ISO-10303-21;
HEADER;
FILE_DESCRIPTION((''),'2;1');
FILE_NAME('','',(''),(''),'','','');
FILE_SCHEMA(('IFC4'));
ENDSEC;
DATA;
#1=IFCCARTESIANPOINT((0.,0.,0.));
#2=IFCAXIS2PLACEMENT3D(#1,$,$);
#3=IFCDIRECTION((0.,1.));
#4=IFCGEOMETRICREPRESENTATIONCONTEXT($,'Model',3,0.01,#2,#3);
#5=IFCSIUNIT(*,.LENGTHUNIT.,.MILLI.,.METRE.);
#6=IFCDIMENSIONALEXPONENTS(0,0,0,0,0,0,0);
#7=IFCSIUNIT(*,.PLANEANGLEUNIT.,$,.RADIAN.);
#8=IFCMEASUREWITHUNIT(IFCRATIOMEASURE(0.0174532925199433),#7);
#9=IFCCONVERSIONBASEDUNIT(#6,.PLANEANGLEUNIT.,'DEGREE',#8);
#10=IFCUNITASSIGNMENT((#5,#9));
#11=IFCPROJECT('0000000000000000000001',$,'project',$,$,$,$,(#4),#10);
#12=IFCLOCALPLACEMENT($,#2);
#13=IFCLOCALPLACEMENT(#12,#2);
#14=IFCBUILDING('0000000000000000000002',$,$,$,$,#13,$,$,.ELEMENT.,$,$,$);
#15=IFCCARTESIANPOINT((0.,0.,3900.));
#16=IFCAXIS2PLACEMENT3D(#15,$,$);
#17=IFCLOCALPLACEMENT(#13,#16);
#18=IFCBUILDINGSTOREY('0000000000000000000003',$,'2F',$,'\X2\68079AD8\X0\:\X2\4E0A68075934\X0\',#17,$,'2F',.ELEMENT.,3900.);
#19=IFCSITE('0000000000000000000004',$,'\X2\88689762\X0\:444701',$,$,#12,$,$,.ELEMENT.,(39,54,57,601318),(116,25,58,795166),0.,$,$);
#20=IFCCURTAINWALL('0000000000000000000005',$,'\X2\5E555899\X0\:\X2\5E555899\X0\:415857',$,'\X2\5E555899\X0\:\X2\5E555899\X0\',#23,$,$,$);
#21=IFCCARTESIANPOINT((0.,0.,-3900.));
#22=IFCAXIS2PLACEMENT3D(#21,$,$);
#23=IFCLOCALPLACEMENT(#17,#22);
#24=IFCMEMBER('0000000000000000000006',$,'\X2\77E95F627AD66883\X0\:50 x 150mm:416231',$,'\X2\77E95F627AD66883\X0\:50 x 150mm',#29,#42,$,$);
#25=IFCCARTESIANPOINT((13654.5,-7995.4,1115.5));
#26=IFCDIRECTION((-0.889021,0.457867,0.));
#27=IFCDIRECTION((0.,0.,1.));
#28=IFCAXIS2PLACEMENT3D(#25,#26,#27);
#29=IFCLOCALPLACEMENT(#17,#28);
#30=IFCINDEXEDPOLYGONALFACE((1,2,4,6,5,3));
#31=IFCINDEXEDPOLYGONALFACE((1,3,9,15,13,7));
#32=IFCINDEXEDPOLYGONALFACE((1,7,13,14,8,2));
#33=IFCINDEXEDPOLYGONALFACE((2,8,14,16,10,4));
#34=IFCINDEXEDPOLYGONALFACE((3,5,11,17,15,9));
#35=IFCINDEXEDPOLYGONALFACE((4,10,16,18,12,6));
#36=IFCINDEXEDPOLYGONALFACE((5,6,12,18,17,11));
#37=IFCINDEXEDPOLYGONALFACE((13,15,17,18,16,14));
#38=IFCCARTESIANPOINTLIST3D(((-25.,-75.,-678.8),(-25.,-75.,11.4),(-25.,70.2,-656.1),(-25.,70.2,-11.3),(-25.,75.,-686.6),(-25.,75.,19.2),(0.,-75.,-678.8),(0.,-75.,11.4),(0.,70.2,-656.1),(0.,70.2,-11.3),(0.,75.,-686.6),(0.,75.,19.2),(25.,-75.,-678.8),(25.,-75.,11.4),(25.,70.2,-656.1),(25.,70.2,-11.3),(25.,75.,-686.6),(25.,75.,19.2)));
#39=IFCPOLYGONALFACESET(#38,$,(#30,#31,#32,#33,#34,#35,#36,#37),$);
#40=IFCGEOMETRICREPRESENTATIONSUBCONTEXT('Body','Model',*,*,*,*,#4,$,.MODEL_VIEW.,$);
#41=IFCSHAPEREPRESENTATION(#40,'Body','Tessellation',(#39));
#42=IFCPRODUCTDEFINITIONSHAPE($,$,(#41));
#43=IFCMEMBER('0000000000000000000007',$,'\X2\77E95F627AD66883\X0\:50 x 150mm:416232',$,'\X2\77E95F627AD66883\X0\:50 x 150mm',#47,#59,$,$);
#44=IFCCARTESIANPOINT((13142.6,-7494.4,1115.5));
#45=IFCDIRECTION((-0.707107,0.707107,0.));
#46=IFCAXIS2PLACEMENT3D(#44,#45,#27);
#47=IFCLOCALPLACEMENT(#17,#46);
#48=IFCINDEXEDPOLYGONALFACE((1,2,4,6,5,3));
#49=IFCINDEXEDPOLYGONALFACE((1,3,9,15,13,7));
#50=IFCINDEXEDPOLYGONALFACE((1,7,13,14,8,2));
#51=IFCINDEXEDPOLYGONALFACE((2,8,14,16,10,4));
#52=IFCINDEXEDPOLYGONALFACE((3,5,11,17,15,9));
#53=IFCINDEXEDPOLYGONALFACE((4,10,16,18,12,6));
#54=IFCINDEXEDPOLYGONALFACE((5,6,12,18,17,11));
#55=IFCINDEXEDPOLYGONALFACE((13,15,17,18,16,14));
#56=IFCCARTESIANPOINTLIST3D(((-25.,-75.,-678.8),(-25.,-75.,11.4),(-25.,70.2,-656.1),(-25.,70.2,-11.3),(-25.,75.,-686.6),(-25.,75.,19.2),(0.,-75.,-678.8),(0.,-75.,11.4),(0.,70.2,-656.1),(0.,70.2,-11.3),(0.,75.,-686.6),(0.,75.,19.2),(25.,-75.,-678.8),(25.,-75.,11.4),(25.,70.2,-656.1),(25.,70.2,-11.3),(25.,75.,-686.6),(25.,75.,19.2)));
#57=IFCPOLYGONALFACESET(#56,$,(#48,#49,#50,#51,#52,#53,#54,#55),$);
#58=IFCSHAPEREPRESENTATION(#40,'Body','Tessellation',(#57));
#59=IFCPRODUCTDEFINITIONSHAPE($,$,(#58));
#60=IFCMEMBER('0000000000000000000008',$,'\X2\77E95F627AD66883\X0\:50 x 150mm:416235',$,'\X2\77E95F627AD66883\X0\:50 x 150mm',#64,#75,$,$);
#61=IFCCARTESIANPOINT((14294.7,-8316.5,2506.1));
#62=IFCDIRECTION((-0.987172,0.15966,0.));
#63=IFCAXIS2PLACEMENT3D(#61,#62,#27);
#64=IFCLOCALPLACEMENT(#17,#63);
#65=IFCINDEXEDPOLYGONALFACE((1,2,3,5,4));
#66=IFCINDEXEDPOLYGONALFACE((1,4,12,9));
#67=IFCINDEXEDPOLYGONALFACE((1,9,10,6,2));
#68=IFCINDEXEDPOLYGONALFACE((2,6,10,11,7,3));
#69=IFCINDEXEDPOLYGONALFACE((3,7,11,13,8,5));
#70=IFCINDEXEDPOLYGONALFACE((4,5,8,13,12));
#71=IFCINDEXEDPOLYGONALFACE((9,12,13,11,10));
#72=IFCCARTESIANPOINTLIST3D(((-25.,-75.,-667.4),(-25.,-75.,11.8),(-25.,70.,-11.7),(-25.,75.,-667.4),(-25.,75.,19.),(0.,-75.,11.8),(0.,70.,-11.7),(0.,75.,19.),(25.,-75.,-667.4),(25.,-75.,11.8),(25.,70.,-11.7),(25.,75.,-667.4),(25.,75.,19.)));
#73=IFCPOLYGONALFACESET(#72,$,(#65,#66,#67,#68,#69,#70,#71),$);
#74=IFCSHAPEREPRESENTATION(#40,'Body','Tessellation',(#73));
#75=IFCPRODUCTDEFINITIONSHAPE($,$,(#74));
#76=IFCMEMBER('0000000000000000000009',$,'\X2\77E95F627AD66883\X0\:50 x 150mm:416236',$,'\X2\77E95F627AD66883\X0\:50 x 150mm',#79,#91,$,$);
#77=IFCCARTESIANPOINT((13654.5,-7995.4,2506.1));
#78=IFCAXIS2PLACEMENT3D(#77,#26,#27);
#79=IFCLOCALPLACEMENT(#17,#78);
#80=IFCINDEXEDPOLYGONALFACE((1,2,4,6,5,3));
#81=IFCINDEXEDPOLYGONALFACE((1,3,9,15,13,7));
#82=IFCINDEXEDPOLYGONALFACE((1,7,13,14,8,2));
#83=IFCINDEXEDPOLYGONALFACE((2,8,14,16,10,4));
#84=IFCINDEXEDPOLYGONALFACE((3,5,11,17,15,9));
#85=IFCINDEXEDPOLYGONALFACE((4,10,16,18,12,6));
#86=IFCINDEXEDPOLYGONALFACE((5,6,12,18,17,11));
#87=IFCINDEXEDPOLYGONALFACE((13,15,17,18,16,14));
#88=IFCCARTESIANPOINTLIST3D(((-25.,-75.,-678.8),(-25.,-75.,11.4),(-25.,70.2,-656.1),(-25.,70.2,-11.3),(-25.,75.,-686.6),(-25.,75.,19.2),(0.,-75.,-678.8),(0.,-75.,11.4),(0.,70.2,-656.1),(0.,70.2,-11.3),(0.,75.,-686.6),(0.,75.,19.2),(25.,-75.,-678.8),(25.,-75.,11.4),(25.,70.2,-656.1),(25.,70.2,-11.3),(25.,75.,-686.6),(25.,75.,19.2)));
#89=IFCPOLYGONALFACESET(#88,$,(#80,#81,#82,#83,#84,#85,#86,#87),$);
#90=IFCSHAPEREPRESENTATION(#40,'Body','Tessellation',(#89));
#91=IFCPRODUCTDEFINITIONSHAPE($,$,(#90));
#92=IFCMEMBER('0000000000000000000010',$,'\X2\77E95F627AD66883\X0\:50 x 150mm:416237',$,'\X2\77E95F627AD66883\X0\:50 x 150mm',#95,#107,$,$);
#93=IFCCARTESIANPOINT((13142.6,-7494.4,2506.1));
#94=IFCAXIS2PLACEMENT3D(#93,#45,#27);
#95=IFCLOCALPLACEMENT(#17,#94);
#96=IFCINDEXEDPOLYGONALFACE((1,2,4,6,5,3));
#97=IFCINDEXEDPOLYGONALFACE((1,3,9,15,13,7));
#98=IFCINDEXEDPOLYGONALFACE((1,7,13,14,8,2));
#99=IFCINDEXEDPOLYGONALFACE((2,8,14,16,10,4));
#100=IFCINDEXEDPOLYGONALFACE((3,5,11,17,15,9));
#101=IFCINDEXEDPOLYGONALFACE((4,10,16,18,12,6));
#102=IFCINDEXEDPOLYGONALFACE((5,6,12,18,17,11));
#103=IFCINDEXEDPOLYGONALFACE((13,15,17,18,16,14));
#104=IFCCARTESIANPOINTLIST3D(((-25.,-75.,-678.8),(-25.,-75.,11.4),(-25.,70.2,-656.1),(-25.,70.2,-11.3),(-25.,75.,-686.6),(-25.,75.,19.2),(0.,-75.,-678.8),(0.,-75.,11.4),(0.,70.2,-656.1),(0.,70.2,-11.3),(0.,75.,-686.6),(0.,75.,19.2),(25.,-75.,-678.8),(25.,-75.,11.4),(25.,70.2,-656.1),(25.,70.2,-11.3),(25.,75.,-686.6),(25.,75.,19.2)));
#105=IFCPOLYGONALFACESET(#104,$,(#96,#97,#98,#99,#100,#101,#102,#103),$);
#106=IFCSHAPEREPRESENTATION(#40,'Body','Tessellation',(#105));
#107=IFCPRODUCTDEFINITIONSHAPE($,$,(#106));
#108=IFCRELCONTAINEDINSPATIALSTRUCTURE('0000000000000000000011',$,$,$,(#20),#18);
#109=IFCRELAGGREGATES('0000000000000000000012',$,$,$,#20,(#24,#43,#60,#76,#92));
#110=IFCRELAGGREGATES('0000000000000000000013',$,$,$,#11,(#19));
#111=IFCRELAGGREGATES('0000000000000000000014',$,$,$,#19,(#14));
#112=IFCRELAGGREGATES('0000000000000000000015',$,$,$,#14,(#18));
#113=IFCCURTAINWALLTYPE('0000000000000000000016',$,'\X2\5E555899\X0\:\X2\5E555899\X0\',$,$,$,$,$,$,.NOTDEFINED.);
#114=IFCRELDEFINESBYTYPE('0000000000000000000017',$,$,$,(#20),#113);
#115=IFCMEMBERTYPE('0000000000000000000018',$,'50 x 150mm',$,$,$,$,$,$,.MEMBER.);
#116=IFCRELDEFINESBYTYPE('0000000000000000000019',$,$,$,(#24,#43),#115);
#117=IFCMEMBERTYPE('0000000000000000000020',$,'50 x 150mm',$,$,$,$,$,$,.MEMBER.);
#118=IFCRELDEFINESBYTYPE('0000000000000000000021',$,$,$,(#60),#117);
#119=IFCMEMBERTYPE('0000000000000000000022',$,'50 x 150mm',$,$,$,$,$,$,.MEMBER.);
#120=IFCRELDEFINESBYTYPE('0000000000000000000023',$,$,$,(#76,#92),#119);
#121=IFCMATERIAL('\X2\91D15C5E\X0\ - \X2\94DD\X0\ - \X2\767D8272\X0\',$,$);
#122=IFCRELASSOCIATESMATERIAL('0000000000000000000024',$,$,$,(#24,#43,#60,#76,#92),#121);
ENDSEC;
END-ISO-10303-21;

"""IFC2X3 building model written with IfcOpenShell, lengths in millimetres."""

from ifc_helpers import new_model, entity, si_unit, converted_unit, direction, frame, origin, origin_2d_with_axis, place, context, subcontext, project, spatial, polyline, rectangle, extrude, clip, bounded_halfspace, source, transform, mapped, material, type_object, type_shapes, element, aggregate, save


model = new_model("IFC2X3")

# Units and contexts
model_context = context("Model", 3, precision=0.01, world=origin(), true_north=direction((0.0, 1.0)))
body_context = subcontext(model_context, "Body", "Model", "MODEL_VIEW")
ifc_project = project(units=[si_unit("LENGTHUNIT", "METRE", prefix="MILLI"), converted_unit("PLANEANGLEUNIT", "DEGREE", entity("IfcRatioMeasure", 0.0174532925199433), si_unit("PLANEANGLEUNIT", "RADIAN"), dimensions=[0, 0, 0, 0, 0, 0, 0])], contexts=[model_context])

# Site, building, storey
site_placement = place(None, origin())
site = spatial("IfcSite", under=ifc_project, at=site_placement, Name="表面:444701", CompositionType="ELEMENT", RefLatitude=(39, 54, 57, 601318), RefLongitude=(116, 25, 58, 795166), RefElevation=0.0)
building_placement = place(site_placement, origin())
building = spatial("IfcBuilding", under=site, at=building_placement, CompositionType="ELEMENT")
storey_placement = place(building_placement, frame((0.0, 0.0, 3900.0)))
storey = spatial("IfcBuildingStorey", under=building, at=storey_placement, Name="2F", ObjectType="标高:上标头", LongName="2F", CompositionType="ELEMENT", Elevation=3900.0)

# Curtain wall, members
curtain_wall_type = type_object("IfcCurtainWallType", Name="幕墙:幕墙", PredefinedType="NOTDEFINED")
curtain_wall_1_placement = place(storey_placement, frame((0.0, 0.0, -3900.0)))
curtain_wall_1 = element("IfcCurtainWall", 1, at=curtain_wall_1_placement, inside=storey, type_object=curtain_wall_type, Name="幕墙:幕墙:415857", ObjectType="幕墙:幕墙")
ifc_material_1 = material(Name="金属 - 铝 - 白色")
member_type_1 = type_object("IfcMemberType", Name="50 x 150mm", PredefinedType="MEMBER")
shared_shape_1 = source(origin(), body_context, "Body", "Clipping", [
    clip(clip(clip(clip(clip(clip(clip(clip(extrude(rectangle(XDim=150.0, YDim=50.0, at=origin_2d_with_axis()), frame((0.0, 0.0, -686.6), z_axis=(0.0, 0.0, 1.0), x_axis=(0.0, -1.0, 0.0)), (0.0, 0.0, 1.0), 705.8), bounded_halfspace(frame((-1415.5, -78.0, -679.3), z_axis=(0.0, 0.154283, -0.988027), x_axis=(1.0, 0.0, 0.0)), False, frame((0.0, 0.0, -686.6), z_axis=(0.0, 0.0, 1.0), x_axis=(0.0, -1.0, 0.0)), polyline([(75.0, 0.0), (75.0, -25.0), (-70.2, -25.0), (-70.2, 0.0), (75.0, 0.0)]))), bounded_halfspace(frame((0.0, -78.0, -679.3), z_axis=(0.0, 0.154283, -0.988027), x_axis=(1.0, 0.0, 0.0)), False, frame((0.0, 0.0, -686.6), z_axis=(0.0, 0.0, 1.0), x_axis=(0.0, -1.0, 0.0)), polyline([(-70.2, 25.0), (75.0, 25.0), (75.0, 0.0), (-70.2, 0.0), (-70.2, 25.0)]))), bounded_halfspace(frame((-1415.5, 70.2, -656.1), z_axis=(0.0, -0.988027, -0.154283), x_axis=(1.0, 0.0, 0.0)), False, frame((0.0, 0.0, -686.6), z_axis=(0.0, 0.0, 1.0), x_axis=(0.0, -1.0, 0.0)), polyline([(-70.2, -25.0), (-75.0, -25.0), (-75.0, 0.0), (-70.2, 0.0), (-70.2, -25.0)]))), bounded_halfspace(frame((0.0, 70.2, -656.1), z_axis=(0.0, -0.988027, -0.154283), x_axis=(1.0, 0.0, 0.0)), False, frame((0.0, 0.0, -686.6), z_axis=(0.0, 0.0, 1.0), x_axis=(0.0, -1.0, 0.0)), polyline([(-75.0, 25.0), (-70.2, 25.0), (-70.2, 0.0), (-75.0, 0.0), (-75.0, 25.0)]))), bounded_halfspace(frame((-1415.5, 78.0, 38.1), z_axis=(0.0, -0.988027, 0.154283), x_axis=(1.0, 0.0, 0.0)), False, frame((0.0, 0.0, -686.6), z_axis=(0.0, 0.0, 1.0), x_axis=(0.0, -1.0, 0.0)), polyline([(-75.0, 0.0), (-75.0, -25.0), (-70.2, -25.0), (-70.2, 0.0), (-75.0, 0.0)]))), bounded_halfspace(frame((0.0, 78.0, 38.1), z_axis=(0.0, -0.988027, 0.154283), x_axis=(1.0, 0.0, 0.0)), False, frame((0.0, 0.0, -686.6), z_axis=(0.0, 0.0, 1.0), x_axis=(0.0, -1.0, 0.0)), polyline([(-75.0, 25.0), (-75.0, 0.0), (-70.2, 0.0), (-70.2, 25.0), (-75.0, 25.0)]))), bounded_halfspace(frame((-1415.5, 70.2, -11.3), z_axis=(0.0, 0.154283, 0.988027), x_axis=(1.0, 0.0, 0.0)), False, frame((0.0, 0.0, -686.6), z_axis=(0.0, 0.0, 1.0), x_axis=(0.0, -1.0, 0.0)), polyline([(-70.2, -25.0), (75.0, -25.0), (75.0, 0.0), (-70.2, 0.0), (-70.2, -25.0)]))), bounded_halfspace(frame((0.0, 70.2, -11.3), z_axis=(0.0, 0.154283, 0.988027), x_axis=(1.0, 0.0, 0.0)), False, frame((0.0, 0.0, -686.6), z_axis=(0.0, 0.0, 1.0), x_axis=(0.0, -1.0, 0.0)), polyline([(75.0, 0.0), (75.0, 25.0), (-70.2, 25.0), (-70.2, 0.0), (75.0, 0.0)]))),
])
type_shapes(member_type_1, [shared_shape_1])
member_1_placement = place(storey_placement, frame((13654.5, -7995.4, 1115.5), z_axis=(-0.889021, 0.457867, 0.0), x_axis=(0.0, 0.0, 1.0)))
member_1 = element("IfcMember", 2, at=member_1_placement, type_object=member_type_1, material=ifc_material_1, Name="矩形竖梃:50 x 150mm:416231", ObjectType="矩形竖梃:50 x 150mm", context=body_context, shape_type="MappedRepresentation", body=[
    mapped(shared_shape_1, transform((0.0, 0.0, 0.0), scale=1.0)),
])
member_2_placement = place(storey_placement, frame((13142.6, -7494.4, 1115.5), z_axis=(-0.707107, 0.707107, 0.0), x_axis=(0.0, 0.0, 1.0)))
member_2 = element("IfcMember", 3, at=member_2_placement, type_object=member_type_1, material=ifc_material_1, Name="矩形竖梃:50 x 150mm:416232", ObjectType="矩形竖梃:50 x 150mm", context=body_context, shape_type="MappedRepresentation", body=[
    mapped(shared_shape_1, transform((0.0, 0.0, 0.0), scale=1.0)),
])

# Members
member_type_2 = type_object("IfcMemberType", Name="50 x 150mm", PredefinedType="MEMBER")
shared_shape_2 = source(origin(), body_context, "Body", "Clipping", [
    clip(clip(clip(clip(extrude(rectangle(XDim=150.0, YDim=50.0, at=origin_2d_with_axis()), frame((0.0, 0.0, -667.4), z_axis=(0.0, 0.0, 1.0), x_axis=(0.0, -1.0, 0.0)), (0.0, 0.0, 1.0), 686.4), bounded_halfspace(frame((-1390.5, 78.0, 37.7), z_axis=(0.0, -0.987172, 0.15966), x_axis=(1.0, 0.0, 0.0)), False, frame((0.0, 0.0, -667.4), z_axis=(0.0, 0.0, 1.0), x_axis=(0.0, -1.0, 0.0)), polyline([(-75.0, 0.0), (-75.0, -25.0), (-70.0, -25.0), (-70.0, 0.0), (-75.0, 0.0)]))), bounded_halfspace(frame((0.0, 78.0, 37.7), z_axis=(0.0, -0.987172, 0.15966), x_axis=(1.0, 0.0, 0.0)), False, frame((0.0, 0.0, -667.4), z_axis=(0.0, 0.0, 1.0), x_axis=(0.0, -1.0, 0.0)), polyline([(-75.0, 25.0), (-75.0, 0.0), (-70.0, 0.0), (-70.0, 25.0), (-75.0, 25.0)]))), bounded_halfspace(frame((-1390.5, 70.0, -11.7), z_axis=(0.0, 0.15966, 0.987172), x_axis=(1.0, 0.0, 0.0)), False, frame((0.0, 0.0, -667.4), z_axis=(0.0, 0.0, 1.0), x_axis=(0.0, -1.0, 0.0)), polyline([(-70.0, -25.0), (75.0, -25.0), (75.0, 0.0), (-70.0, 0.0), (-70.0, -25.0)]))), bounded_halfspace(frame((0.0, 70.0, -11.7), z_axis=(0.0, 0.15966, 0.987172), x_axis=(1.0, 0.0, 0.0)), False, frame((0.0, 0.0, -667.4), z_axis=(0.0, 0.0, 1.0), x_axis=(0.0, -1.0, 0.0)), polyline([(75.0, 0.0), (75.0, 25.0), (-70.0, 25.0), (-70.0, 0.0), (75.0, 0.0)]))),
])
type_shapes(member_type_2, [shared_shape_2])
member_3_placement = place(storey_placement, frame((14294.7, -8316.5, 2506.1), z_axis=(-0.987172, 0.15966, 0.0), x_axis=(0.0, 0.0, 1.0)))
member_3 = element("IfcMember", 4, at=member_3_placement, type_object=member_type_2, material=ifc_material_1, Name="矩形竖梃:50 x 150mm:416235", ObjectType="矩形竖梃:50 x 150mm", context=body_context, shape_type="MappedRepresentation", body=[
    mapped(shared_shape_2, transform((0.0, 0.0, 0.0), scale=1.0)),
])
member_type_3 = type_object("IfcMemberType", Name="50 x 150mm", PredefinedType="MEMBER")
shared_shape_3 = source(origin(), body_context, "Body", "Clipping", [
    clip(clip(clip(clip(clip(clip(clip(clip(extrude(rectangle(XDim=150.0, YDim=50.0, at=origin_2d_with_axis()), frame((0.0, 0.0, -686.6), z_axis=(0.0, 0.0, 1.0), x_axis=(0.0, -1.0, 0.0)), (0.0, 0.0, 1.0), 705.8), bounded_halfspace(frame((-1390.5, -78.0, -679.3), z_axis=(0.0, 0.154283, -0.988027), x_axis=(1.0, 0.0, 0.0)), False, frame((0.0, 0.0, -686.6), z_axis=(0.0, 0.0, 1.0), x_axis=(0.0, -1.0, 0.0)), polyline([(75.0, 0.0), (75.0, -25.0), (-70.2, -25.0), (-70.2, 0.0), (75.0, 0.0)]))), bounded_halfspace(frame((0.0, -78.0, -679.3), z_axis=(0.0, 0.154283, -0.988027), x_axis=(1.0, 0.0, 0.0)), False, frame((0.0, 0.0, -686.6), z_axis=(0.0, 0.0, 1.0), x_axis=(0.0, -1.0, 0.0)), polyline([(-70.2, 25.0), (75.0, 25.0), (75.0, 0.0), (-70.2, 0.0), (-70.2, 25.0)]))), bounded_halfspace(frame((-1390.5, 70.2, -656.1), z_axis=(0.0, -0.988027, -0.154283), x_axis=(1.0, 0.0, 0.0)), False, frame((0.0, 0.0, -686.6), z_axis=(0.0, 0.0, 1.0), x_axis=(0.0, -1.0, 0.0)), polyline([(-70.2, -25.0), (-75.0, -25.0), (-75.0, 0.0), (-70.2, 0.0), (-70.2, -25.0)]))), bounded_halfspace(frame((0.0, 70.2, -656.1), z_axis=(0.0, -0.988027, -0.154283), x_axis=(1.0, 0.0, 0.0)), False, frame((0.0, 0.0, -686.6), z_axis=(0.0, 0.0, 1.0), x_axis=(0.0, -1.0, 0.0)), polyline([(-75.0, 25.0), (-70.2, 25.0), (-70.2, 0.0), (-75.0, 0.0), (-75.0, 25.0)]))), bounded_halfspace(frame((-1390.5, 78.0, 38.1), z_axis=(0.0, -0.988027, 0.154283), x_axis=(1.0, 0.0, 0.0)), False, frame((0.0, 0.0, -686.6), z_axis=(0.0, 0.0, 1.0), x_axis=(0.0, -1.0, 0.0)), polyline([(-75.0, 0.0), (-75.0, -25.0), (-70.2, -25.0), (-70.2, 0.0), (-75.0, 0.0)]))), bounded_halfspace(frame((0.0, 78.0, 38.1), z_axis=(0.0, -0.988027, 0.154283), x_axis=(1.0, 0.0, 0.0)), False, frame((0.0, 0.0, -686.6), z_axis=(0.0, 0.0, 1.0), x_axis=(0.0, -1.0, 0.0)), polyline([(-75.0, 25.0), (-75.0, 0.0), (-70.2, 0.0), (-70.2, 25.0), (-75.0, 25.0)]))), bounded_halfspace(frame((-1390.5, 70.2, -11.3), z_axis=(0.0, 0.154283, 0.988027), x_axis=(1.0, 0.0, 0.0)), False, frame((0.0, 0.0, -686.6), z_axis=(0.0, 0.0, 1.0), x_axis=(0.0, -1.0, 0.0)), polyline([(-70.2, -25.0), (75.0, -25.0), (75.0, 0.0), (-70.2, 0.0), (-70.2, -25.0)]))), bounded_halfspace(frame((0.0, 70.2, -11.3), z_axis=(0.0, 0.154283, 0.988027), x_axis=(1.0, 0.0, 0.0)), False, frame((0.0, 0.0, -686.6), z_axis=(0.0, 0.0, 1.0), x_axis=(0.0, -1.0, 0.0)), polyline([(75.0, 0.0), (75.0, 25.0), (-70.2, 25.0), (-70.2, 0.0), (75.0, 0.0)]))),
])
type_shapes(member_type_3, [shared_shape_3])
member_4_placement = place(storey_placement, frame((13654.5, -7995.4, 2506.1), z_axis=(-0.889021, 0.457867, 0.0), x_axis=(0.0, 0.0, 1.0)))
member_4 = element("IfcMember", 5, at=member_4_placement, type_object=member_type_3, material=ifc_material_1, Name="矩形竖梃:50 x 150mm:416236", ObjectType="矩形竖梃:50 x 150mm", context=body_context, shape_type="MappedRepresentation", body=[
    mapped(shared_shape_3, transform((0.0, 0.0, 0.0), scale=1.0)),
])
member_5_placement = place(storey_placement, frame((13142.6, -7494.4, 2506.1), z_axis=(-0.707107, 0.707107, 0.0), x_axis=(0.0, 0.0, 1.0)))
member_5 = element("IfcMember", 6, at=member_5_placement, type_object=member_type_3, material=ifc_material_1, Name="矩形竖梃:50 x 150mm:416237", ObjectType="矩形竖梃:50 x 150mm", context=body_context, shape_type="MappedRepresentation", body=[
    mapped(shared_shape_3, transform((0.0, 0.0, 0.0), scale=1.0)),
])

aggregate(curtain_wall_1, [member_1, member_2, member_3, member_4, member_5])

save(model, "model.ifc")
